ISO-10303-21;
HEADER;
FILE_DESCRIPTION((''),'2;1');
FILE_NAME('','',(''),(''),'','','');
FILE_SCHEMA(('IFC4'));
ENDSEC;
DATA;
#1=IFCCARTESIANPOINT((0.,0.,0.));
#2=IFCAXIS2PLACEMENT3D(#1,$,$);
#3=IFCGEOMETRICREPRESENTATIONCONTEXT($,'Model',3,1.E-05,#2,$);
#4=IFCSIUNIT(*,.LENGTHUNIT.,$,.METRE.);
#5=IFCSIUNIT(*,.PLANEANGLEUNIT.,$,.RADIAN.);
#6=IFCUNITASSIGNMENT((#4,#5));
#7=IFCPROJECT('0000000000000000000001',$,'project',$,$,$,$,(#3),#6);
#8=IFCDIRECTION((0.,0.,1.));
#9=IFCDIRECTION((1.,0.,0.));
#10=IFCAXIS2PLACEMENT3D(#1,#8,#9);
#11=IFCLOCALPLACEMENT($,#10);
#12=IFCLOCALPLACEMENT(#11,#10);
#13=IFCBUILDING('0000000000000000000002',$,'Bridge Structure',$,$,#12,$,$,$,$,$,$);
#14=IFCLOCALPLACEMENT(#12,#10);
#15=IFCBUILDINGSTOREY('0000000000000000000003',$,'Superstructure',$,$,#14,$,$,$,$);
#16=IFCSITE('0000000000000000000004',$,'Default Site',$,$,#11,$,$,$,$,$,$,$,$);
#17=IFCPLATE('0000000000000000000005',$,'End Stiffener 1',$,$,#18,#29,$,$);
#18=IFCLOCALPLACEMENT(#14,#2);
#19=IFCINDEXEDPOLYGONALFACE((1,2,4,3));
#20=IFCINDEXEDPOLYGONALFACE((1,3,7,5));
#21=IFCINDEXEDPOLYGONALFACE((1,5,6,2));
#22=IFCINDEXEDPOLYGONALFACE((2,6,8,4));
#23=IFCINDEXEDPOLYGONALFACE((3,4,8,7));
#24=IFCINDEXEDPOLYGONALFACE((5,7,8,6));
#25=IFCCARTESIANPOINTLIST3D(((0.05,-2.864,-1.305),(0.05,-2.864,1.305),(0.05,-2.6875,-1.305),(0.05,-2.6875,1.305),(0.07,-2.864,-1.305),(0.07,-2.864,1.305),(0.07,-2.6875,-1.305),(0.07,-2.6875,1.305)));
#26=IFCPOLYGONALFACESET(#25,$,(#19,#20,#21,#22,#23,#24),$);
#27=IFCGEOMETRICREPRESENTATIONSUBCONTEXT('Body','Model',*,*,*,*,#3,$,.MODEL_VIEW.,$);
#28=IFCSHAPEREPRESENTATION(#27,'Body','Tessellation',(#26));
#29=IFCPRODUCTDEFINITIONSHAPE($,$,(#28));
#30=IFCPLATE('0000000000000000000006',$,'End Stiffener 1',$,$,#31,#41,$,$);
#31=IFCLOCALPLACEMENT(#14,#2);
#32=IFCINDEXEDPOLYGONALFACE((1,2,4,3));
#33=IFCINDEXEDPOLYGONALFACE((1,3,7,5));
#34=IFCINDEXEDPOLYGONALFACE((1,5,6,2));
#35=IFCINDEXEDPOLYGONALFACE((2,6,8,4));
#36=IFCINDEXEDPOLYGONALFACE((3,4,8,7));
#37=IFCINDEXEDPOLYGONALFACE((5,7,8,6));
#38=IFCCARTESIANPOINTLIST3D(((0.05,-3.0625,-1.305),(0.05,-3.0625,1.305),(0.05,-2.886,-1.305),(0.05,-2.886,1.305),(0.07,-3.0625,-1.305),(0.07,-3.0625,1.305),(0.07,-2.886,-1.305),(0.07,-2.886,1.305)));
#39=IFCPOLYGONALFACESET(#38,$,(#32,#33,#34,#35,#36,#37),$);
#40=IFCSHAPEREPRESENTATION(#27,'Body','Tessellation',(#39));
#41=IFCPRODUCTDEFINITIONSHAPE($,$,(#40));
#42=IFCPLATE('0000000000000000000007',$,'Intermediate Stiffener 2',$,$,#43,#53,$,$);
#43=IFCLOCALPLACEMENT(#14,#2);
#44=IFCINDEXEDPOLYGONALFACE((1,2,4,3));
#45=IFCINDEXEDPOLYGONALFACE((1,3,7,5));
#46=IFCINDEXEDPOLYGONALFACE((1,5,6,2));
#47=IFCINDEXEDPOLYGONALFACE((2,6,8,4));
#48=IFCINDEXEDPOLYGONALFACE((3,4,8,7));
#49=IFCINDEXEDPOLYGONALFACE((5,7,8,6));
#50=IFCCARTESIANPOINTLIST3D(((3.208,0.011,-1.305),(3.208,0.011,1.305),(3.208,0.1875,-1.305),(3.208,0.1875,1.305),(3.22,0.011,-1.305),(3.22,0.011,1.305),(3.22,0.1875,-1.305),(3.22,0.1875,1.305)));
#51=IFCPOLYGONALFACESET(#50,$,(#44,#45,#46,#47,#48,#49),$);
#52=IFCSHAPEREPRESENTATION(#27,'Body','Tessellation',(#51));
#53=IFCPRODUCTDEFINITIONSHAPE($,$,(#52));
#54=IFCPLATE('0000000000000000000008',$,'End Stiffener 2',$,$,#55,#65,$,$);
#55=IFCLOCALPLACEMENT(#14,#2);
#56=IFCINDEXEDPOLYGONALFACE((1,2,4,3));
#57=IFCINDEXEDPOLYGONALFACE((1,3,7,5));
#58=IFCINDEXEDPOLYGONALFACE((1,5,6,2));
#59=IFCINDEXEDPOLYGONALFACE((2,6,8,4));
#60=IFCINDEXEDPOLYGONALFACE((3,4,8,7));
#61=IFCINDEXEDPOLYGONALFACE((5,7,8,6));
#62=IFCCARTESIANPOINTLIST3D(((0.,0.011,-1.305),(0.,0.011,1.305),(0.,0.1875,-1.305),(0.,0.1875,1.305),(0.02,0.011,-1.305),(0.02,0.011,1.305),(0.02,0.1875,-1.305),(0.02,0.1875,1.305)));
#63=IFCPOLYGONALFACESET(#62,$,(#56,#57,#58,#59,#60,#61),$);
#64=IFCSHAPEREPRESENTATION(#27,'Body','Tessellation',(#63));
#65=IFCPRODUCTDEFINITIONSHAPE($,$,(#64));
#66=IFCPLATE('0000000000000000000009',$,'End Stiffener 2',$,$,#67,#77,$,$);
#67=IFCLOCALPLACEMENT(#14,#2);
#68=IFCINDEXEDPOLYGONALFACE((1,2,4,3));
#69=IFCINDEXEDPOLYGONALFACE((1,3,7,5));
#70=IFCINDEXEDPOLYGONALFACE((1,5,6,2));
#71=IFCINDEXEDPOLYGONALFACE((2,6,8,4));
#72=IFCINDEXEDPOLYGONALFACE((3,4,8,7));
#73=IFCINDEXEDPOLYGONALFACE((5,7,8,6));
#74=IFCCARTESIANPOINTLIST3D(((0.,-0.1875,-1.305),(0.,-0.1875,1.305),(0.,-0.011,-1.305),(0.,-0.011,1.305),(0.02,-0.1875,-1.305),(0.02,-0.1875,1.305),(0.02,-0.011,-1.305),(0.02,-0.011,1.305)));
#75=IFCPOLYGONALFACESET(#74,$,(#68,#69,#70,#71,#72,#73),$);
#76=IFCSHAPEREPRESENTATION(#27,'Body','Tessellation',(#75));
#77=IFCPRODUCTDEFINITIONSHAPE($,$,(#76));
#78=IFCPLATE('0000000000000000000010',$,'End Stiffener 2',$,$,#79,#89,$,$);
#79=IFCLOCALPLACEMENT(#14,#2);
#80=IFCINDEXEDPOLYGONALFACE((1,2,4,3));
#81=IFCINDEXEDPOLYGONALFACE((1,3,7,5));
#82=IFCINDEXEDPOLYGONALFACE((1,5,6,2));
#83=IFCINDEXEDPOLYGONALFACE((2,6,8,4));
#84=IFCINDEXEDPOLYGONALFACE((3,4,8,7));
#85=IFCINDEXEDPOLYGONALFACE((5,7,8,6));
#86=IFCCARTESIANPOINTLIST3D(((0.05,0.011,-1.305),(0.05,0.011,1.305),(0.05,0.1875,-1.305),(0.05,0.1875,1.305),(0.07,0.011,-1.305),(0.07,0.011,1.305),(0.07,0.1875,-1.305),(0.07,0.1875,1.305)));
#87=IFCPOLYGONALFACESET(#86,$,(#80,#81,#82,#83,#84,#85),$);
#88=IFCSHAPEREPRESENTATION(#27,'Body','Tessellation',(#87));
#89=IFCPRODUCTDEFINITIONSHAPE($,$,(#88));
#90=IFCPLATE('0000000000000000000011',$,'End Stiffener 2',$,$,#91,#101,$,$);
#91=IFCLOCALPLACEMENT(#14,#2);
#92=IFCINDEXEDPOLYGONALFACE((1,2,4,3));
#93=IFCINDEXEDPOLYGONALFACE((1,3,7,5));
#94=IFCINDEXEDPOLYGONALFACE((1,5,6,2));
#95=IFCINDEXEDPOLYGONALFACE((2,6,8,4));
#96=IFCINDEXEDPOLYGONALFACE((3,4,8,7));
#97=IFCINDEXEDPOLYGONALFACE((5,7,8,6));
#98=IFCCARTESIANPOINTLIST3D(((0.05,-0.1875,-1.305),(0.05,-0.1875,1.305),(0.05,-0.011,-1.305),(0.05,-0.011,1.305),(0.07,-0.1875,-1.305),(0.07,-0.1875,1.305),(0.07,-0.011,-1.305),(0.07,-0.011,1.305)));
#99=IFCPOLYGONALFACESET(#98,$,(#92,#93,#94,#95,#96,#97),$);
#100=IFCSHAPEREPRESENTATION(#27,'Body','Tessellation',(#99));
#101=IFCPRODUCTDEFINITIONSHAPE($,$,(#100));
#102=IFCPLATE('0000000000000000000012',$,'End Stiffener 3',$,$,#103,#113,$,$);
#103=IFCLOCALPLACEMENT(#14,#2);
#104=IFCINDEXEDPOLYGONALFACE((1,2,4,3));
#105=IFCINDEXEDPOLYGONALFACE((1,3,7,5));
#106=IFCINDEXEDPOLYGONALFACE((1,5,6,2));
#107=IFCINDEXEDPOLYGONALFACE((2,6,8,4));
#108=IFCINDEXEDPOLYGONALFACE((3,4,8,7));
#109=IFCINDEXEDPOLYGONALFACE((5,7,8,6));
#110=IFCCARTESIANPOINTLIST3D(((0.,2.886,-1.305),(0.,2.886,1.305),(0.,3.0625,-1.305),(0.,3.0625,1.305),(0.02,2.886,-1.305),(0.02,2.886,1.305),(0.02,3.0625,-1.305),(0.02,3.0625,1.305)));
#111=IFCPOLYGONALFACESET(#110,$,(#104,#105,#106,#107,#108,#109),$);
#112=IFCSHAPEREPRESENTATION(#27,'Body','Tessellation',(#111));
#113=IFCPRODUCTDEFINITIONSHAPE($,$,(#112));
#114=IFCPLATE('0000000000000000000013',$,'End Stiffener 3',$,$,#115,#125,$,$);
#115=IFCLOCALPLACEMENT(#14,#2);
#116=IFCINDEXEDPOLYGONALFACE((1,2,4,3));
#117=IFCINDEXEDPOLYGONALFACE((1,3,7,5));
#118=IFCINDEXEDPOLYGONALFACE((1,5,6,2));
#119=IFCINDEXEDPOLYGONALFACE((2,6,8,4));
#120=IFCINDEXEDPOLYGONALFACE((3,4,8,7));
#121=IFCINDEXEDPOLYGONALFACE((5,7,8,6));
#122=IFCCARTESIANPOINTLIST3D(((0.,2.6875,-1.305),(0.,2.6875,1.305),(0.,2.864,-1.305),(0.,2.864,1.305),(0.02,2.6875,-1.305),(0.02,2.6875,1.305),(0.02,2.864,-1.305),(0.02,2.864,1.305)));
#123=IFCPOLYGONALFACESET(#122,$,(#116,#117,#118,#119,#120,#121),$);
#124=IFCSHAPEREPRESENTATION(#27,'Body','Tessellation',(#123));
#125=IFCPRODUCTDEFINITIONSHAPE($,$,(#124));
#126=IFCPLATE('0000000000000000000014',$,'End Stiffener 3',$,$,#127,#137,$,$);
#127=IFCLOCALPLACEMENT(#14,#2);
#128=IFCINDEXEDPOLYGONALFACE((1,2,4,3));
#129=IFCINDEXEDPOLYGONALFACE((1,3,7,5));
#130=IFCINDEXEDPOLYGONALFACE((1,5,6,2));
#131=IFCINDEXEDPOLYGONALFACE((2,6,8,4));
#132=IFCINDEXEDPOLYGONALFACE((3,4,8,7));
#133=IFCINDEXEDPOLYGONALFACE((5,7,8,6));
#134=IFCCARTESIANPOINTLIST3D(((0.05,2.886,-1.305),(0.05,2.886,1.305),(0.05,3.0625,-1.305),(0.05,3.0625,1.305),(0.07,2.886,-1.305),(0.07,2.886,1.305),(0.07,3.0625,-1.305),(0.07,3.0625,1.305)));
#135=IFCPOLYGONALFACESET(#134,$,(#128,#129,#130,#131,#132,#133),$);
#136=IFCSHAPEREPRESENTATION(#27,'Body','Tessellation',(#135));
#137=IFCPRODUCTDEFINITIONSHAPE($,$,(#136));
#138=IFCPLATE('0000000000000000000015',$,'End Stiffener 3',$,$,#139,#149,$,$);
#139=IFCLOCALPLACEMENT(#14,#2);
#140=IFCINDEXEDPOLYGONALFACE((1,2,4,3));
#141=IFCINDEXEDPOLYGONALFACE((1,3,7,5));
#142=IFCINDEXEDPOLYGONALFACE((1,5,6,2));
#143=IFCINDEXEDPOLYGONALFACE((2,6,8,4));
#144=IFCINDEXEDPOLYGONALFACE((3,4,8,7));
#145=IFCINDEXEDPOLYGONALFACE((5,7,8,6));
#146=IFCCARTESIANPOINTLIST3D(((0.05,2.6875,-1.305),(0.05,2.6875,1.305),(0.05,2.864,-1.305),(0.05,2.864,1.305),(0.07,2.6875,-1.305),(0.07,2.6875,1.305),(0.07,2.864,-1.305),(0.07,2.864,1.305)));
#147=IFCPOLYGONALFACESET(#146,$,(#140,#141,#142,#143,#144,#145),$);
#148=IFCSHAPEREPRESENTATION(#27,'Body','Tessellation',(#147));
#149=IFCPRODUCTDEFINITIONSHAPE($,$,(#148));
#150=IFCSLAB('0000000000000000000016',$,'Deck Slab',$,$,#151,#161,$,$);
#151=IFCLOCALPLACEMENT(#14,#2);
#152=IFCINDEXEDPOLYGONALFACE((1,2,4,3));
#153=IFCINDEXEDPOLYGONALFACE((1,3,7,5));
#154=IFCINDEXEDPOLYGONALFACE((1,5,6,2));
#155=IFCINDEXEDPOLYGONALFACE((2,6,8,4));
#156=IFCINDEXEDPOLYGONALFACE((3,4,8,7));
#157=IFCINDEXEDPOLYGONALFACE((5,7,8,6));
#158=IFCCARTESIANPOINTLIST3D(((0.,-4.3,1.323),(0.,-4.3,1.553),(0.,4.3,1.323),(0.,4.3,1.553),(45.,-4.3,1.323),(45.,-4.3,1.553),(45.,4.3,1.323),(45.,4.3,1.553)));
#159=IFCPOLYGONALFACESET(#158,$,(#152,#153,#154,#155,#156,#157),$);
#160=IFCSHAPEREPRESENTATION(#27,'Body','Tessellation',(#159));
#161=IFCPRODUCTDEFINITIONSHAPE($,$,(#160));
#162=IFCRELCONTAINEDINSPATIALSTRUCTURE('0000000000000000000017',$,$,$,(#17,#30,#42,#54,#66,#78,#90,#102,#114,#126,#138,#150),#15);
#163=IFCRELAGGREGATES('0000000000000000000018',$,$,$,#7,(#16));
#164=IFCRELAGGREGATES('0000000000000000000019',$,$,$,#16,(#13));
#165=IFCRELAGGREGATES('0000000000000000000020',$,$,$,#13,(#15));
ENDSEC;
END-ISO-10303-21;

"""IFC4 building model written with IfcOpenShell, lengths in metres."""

from ifc_helpers import new_model, si_unit, frame, origin, origin_with_axes, origin_2d_with_axis, place, context, subcontext, project, spatial, polyline, rectangle, outline, extrude, element, save


model = new_model("IFC4")

# Units and contexts
model_context = context("Model", 3, precision=1e-05, world=origin())
body_context = subcontext(model_context, "Body", "Model", "MODEL_VIEW")
ifc_project = project(units=[si_unit("LENGTHUNIT", "METRE"), si_unit("PLANEANGLEUNIT", "RADIAN")], contexts=[model_context])

# Site, building, storey
site_placement = place(None, origin_with_axes())
site = spatial("IfcSite", under=ifc_project, at=site_placement, Name="Default Site")
building_placement = place(site_placement, origin_with_axes())
building = spatial("IfcBuilding", under=site, at=building_placement, Name="Bridge Structure")
storey_placement = place(building_placement, origin_with_axes())
storey = spatial("IfcBuildingStorey", under=building, at=storey_placement, Name="Superstructure")

# Plates
for number, where, z_axis, x_axis, name in (
    (1, (0.06, -2.7757, -1.305), (0.0, 0.0, 1.0), (1.0, 0.0, 0.0), "End Stiffener 1"),
    (2, (0.06, -2.9743, -1.305), (0.0, 0.0, 1.0), (1.0, 0.0, 0.0), "End Stiffener 1"),
):
    element("IfcPlate", number, at=place(storey_placement, frame(where, z_axis=z_axis, x_axis=x_axis)), inside=storey, Name=name, context=body_context, shape_type="SweptSolid", body=[
        extrude(rectangle(XDim=0.02, YDim=0.1765, at=origin_2d_with_axis()), origin_with_axes(), (0.0, 0.0, 1.0), 2.61),
    ])
plate_1_placement = place(storey_placement, frame((3.214, 0.0993, -1.305), z_axis=(0.0, 0.0, 1.0), x_axis=(1.0, 0.0, 0.0)))
element("IfcPlate", 3, at=plate_1_placement, inside=storey, Name="Intermediate Stiffener 2", context=body_context, shape_type="SweptSolid", body=[
    extrude(rectangle(XDim=0.012, YDim=0.1765, at=origin_2d_with_axis()), origin_with_axes(), (0.0, 0.0, 1.0), 2.61),
])
for number, where, z_axis, x_axis, name in (
    (4, (0.01, 0.0993, -1.305), (0.0, 0.0, 1.0), (1.0, 0.0, 0.0), "End Stiffener 2"),
    (5, (0.01, -0.0993, -1.305), (0.0, 0.0, 1.0), (1.0, 0.0, 0.0), "End Stiffener 2"),
    (6, (0.06, 0.0993, -1.305), (0.0, 0.0, 1.0), (1.0, 0.0, 0.0), "End Stiffener 2"),
    (7, (0.06, -0.0993, -1.305), (0.0, 0.0, 1.0), (1.0, 0.0, 0.0), "End Stiffener 2"),
    (8, (0.01, 2.9743, -1.305), (0.0, 0.0, 1.0), (1.0, 0.0, 0.0), "End Stiffener 3"),
    (9, (0.01, 2.7757, -1.305), (0.0, 0.0, 1.0), (1.0, 0.0, 0.0), "End Stiffener 3"),
    (10, (0.06, 2.9743, -1.305), (0.0, 0.0, 1.0), (1.0, 0.0, 0.0), "End Stiffener 3"),
    (11, (0.06, 2.7757, -1.305), (0.0, 0.0, 1.0), (1.0, 0.0, 0.0), "End Stiffener 3"),
):
    element("IfcPlate", number, at=place(storey_placement, frame(where, z_axis=z_axis, x_axis=x_axis)), inside=storey, Name=name, context=body_context, shape_type="SweptSolid", body=[
        extrude(rectangle(XDim=0.02, YDim=0.1765, at=origin_2d_with_axis()), origin_with_axes(), (0.0, 0.0, 1.0), 2.61),
    ])

# Slab
slab_placement = place(storey_placement, frame((0.0, 0.0, 1.323), z_axis=(0.0, 0.0, 1.0), x_axis=(1.0, 0.0, 0.0)))
element("IfcSlab", 12, at=slab_placement, inside=storey, Name="Deck Slab", context=body_context, shape_type="SweptSolid", body=[
    extrude(outline(polyline([(0.0, -4.3), (45.0, -4.3), (45.0, 4.3), (0.0, 4.3), (0.0, -4.3)])), origin_with_axes(), (0.0, 0.0, 1.0), 0.23),
])

save(model, "model.ifc")
